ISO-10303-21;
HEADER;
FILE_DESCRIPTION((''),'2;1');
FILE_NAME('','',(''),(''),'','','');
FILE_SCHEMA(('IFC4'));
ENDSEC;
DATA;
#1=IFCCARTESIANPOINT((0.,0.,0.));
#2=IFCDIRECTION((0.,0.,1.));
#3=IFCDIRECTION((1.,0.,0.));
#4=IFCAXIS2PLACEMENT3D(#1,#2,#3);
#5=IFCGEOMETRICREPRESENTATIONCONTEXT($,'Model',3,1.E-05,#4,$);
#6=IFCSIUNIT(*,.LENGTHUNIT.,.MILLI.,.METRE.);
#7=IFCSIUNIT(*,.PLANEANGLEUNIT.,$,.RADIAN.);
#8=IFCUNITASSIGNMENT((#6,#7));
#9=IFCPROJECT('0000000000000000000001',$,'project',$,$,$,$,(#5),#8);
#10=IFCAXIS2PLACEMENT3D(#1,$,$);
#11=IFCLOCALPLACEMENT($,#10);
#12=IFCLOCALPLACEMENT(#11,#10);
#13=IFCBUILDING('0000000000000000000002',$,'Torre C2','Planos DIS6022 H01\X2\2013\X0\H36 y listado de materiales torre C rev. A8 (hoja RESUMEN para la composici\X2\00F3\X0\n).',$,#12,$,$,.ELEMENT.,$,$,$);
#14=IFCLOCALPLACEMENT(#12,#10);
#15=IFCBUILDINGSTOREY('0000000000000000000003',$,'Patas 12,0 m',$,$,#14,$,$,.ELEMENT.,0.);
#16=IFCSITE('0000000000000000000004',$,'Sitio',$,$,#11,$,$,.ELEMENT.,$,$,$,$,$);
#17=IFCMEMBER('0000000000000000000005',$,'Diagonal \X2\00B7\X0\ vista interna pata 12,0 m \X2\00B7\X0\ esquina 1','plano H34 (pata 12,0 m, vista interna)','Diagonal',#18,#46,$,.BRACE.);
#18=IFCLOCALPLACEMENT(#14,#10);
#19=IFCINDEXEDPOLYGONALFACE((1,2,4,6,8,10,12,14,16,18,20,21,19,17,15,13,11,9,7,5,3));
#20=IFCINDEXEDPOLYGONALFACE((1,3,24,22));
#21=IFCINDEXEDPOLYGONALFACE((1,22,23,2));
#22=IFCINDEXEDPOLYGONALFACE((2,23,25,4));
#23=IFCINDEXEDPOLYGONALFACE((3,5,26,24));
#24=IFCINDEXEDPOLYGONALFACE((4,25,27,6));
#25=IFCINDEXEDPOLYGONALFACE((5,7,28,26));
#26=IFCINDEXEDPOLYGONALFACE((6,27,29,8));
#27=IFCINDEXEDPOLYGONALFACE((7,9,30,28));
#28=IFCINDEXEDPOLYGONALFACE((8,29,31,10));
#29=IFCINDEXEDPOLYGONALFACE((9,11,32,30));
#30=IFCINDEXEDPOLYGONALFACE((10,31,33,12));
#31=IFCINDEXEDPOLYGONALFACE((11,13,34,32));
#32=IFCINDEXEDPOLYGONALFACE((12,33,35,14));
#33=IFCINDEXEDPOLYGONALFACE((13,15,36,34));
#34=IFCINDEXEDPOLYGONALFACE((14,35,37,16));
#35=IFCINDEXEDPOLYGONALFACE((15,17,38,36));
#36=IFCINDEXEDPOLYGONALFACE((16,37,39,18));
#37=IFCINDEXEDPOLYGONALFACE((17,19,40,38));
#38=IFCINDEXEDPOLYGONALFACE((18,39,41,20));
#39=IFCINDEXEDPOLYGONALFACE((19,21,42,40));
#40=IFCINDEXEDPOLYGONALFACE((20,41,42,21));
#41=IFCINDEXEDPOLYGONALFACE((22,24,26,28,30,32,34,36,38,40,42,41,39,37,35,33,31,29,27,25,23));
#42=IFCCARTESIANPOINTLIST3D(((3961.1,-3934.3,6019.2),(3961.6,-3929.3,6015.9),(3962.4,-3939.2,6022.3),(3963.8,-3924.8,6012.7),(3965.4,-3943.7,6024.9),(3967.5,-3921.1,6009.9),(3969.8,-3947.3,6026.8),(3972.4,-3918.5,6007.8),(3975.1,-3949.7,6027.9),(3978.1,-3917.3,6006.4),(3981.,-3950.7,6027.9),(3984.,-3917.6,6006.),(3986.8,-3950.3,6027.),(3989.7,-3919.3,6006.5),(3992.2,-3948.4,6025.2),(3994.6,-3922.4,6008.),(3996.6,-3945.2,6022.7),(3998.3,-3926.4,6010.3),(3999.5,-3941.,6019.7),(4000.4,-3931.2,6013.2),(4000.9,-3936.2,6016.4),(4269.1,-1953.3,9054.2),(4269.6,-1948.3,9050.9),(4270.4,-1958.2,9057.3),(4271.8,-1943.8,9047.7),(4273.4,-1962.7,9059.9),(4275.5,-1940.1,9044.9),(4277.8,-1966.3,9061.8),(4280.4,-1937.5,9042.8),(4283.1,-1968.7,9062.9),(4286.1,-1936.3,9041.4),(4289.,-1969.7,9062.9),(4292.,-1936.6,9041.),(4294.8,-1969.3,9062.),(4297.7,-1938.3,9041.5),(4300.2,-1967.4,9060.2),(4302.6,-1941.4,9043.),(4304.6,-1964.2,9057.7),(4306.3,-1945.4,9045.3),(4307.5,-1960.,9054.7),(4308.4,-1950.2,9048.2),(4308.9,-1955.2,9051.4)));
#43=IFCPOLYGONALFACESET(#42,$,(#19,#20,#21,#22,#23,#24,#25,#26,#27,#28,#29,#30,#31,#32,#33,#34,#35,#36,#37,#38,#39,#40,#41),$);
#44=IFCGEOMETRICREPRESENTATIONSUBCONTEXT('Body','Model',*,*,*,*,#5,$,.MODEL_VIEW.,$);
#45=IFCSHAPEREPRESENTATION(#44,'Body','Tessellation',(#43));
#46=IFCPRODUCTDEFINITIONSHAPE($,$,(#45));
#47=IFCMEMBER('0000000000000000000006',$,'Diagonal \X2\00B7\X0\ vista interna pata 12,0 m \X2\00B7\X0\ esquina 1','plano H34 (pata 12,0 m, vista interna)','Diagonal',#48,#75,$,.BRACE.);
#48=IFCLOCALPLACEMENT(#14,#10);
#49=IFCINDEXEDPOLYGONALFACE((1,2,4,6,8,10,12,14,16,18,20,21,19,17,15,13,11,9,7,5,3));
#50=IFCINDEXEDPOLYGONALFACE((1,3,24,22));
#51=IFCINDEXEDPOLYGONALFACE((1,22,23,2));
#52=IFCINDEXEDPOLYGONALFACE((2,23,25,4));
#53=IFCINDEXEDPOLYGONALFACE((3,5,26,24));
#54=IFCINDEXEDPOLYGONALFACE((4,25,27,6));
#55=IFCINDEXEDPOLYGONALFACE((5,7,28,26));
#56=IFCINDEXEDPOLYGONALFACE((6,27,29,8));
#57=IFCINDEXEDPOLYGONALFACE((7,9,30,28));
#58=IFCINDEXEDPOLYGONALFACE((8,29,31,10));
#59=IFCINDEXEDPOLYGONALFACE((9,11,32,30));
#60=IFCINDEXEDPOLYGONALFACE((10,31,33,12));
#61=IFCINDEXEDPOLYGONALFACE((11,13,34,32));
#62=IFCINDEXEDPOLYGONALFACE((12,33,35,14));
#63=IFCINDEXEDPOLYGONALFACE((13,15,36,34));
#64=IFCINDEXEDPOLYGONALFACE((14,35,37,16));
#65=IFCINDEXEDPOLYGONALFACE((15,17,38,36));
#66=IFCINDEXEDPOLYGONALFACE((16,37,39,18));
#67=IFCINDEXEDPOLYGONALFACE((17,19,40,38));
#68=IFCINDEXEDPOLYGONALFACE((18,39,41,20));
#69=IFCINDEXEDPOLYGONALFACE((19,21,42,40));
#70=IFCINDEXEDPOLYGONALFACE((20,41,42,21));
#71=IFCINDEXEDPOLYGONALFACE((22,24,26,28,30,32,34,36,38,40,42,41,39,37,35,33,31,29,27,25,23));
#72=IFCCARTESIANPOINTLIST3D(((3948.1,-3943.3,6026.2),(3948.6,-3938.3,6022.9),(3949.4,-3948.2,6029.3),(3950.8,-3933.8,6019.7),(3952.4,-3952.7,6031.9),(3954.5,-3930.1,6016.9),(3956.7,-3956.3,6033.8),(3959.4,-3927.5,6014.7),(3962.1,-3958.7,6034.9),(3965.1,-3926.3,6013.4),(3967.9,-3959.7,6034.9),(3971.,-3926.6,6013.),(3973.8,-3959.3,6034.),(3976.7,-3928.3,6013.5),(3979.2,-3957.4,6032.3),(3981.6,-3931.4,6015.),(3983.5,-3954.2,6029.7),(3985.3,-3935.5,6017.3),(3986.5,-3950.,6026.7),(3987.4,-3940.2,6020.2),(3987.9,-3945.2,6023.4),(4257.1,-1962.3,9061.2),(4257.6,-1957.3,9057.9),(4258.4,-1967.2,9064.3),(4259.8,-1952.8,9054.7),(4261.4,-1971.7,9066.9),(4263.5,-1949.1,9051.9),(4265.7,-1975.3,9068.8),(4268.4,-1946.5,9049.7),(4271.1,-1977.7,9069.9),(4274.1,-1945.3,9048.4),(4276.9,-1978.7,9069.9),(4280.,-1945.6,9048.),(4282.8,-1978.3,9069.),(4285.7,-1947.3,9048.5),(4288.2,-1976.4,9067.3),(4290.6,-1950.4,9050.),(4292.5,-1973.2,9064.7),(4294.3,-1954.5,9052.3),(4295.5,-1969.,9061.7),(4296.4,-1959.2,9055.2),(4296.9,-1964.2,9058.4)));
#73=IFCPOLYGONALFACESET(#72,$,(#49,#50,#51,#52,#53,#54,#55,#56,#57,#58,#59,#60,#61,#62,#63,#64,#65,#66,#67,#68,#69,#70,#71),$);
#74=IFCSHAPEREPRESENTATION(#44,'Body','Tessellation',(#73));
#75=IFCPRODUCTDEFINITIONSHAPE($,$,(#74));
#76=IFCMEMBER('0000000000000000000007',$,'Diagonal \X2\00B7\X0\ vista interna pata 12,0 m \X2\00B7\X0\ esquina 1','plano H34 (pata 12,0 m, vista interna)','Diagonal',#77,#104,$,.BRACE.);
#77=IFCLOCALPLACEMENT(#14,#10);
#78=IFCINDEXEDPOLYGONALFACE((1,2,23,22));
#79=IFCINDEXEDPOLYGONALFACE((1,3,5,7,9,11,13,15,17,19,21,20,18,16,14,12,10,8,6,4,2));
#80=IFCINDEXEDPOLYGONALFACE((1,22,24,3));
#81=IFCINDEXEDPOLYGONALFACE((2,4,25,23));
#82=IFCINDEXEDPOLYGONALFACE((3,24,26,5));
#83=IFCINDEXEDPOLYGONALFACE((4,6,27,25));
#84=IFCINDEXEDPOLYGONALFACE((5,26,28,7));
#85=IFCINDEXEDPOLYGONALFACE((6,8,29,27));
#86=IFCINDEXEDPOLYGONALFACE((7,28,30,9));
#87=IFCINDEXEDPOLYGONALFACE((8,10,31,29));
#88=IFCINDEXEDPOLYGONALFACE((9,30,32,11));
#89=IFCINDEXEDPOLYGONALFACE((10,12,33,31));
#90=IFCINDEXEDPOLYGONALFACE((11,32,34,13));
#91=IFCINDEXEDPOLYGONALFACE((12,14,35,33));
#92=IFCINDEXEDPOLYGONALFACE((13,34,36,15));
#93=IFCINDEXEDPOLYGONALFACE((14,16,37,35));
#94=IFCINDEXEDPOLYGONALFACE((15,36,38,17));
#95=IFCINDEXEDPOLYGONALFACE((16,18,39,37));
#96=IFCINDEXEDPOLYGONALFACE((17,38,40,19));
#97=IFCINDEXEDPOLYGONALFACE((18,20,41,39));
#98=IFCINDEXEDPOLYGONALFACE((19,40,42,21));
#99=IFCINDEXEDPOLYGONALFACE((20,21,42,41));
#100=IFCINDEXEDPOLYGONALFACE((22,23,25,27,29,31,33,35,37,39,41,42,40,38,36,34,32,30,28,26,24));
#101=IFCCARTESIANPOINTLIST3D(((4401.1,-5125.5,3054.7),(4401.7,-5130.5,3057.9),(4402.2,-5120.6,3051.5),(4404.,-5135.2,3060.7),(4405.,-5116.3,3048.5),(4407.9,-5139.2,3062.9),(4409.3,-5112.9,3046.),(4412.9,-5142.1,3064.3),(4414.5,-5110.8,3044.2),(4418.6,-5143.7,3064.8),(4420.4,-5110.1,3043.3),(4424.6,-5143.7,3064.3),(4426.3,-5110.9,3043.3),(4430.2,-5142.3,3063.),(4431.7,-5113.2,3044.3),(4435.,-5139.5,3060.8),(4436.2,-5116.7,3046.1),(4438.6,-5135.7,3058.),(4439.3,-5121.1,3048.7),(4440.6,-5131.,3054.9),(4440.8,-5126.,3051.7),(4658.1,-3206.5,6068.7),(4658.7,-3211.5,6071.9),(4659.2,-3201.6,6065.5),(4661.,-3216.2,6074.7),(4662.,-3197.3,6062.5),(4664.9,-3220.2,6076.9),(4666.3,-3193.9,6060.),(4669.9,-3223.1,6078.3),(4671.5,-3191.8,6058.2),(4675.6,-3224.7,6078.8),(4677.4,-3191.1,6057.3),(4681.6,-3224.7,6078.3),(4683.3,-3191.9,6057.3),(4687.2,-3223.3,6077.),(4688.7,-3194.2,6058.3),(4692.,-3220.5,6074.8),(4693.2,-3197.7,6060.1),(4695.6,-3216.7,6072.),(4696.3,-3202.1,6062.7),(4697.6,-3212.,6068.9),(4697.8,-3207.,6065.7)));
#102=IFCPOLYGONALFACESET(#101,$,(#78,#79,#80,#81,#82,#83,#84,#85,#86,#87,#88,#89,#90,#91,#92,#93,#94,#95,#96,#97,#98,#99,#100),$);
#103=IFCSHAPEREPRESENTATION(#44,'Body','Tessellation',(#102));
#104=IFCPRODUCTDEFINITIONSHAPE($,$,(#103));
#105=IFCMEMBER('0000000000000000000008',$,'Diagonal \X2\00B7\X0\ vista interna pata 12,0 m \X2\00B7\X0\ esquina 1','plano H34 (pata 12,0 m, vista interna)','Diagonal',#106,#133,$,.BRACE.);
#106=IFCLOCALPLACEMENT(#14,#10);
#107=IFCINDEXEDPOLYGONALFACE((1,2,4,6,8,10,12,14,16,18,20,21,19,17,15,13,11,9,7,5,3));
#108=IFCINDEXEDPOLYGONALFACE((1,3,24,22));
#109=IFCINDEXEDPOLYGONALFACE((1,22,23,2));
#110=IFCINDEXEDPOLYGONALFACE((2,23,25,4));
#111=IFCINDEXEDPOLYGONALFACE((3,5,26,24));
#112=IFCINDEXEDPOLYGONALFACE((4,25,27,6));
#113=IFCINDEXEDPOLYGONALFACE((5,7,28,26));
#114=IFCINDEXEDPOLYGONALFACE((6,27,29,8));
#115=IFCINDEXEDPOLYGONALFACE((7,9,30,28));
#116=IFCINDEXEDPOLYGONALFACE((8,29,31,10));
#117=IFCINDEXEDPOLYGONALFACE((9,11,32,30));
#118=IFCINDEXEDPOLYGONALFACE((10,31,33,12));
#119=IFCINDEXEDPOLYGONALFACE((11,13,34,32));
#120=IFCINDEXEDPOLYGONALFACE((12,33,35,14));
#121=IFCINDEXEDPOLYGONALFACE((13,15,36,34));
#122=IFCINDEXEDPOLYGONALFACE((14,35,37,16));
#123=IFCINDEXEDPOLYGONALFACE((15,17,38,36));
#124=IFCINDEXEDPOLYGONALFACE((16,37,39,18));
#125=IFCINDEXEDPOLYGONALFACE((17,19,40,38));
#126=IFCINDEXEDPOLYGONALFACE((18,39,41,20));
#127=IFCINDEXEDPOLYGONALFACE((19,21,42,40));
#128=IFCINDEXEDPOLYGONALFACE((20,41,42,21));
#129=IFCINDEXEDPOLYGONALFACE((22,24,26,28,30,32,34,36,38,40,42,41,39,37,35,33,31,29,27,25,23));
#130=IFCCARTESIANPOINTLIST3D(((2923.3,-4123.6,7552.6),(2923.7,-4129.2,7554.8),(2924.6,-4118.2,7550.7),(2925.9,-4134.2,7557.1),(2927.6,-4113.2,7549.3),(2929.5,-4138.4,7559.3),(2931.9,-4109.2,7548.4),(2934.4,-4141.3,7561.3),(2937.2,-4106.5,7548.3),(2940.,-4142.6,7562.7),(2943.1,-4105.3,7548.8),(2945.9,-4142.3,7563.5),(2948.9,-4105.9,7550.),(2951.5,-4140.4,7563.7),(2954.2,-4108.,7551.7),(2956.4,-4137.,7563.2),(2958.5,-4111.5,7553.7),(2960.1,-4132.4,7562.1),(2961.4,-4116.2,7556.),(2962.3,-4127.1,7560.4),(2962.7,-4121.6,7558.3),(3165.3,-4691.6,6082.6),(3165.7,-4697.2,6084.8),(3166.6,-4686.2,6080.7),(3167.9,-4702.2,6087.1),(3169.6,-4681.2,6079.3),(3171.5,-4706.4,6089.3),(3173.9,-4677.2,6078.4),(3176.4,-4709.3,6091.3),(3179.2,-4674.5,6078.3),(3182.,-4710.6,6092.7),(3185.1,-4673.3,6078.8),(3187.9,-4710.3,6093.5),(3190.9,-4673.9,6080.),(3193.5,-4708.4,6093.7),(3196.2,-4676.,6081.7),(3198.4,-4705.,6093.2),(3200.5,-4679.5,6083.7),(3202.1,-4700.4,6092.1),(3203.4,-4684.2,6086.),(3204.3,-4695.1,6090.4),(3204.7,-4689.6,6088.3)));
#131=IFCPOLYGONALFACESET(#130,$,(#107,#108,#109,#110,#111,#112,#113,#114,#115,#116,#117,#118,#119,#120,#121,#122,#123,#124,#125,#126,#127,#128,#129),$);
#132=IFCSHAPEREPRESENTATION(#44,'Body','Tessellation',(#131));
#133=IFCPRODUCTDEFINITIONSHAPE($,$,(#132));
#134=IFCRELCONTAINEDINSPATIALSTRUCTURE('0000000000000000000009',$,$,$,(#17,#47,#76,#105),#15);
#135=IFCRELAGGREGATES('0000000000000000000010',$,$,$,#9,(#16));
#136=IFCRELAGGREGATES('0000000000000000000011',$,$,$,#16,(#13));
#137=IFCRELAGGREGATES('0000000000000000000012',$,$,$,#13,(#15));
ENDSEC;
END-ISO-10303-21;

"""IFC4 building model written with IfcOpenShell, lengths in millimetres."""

from ifc_helpers import new_model, si_unit, frame, origin, origin_with_axes, place, context, subcontext, project, spatial, circle, extrude, element, save


model = new_model("IFC4")

# Units and contexts
model_context = context("Model", 3, precision=1e-05, world=origin_with_axes())
body_context = subcontext(model_context, "Body", "Model", "MODEL_VIEW")
ifc_project = project(units=[si_unit("LENGTHUNIT", "METRE", prefix="MILLI"), si_unit("PLANEANGLEUNIT", "RADIAN")], contexts=[model_context])

# Site, building, storey
site_placement = place(None, origin())
site = spatial("IfcSite", under=ifc_project, at=site_placement, Name="Sitio", CompositionType="ELEMENT")
building_placement = place(site_placement, origin())
building = spatial("IfcBuilding", under=site, at=building_placement, Name="Torre C2", Description="Planos DIS6022 H01–H36 y listado de materiales torre C rev. A8 (hoja RESUMEN para la composición).", CompositionType="ELEMENT")
storey_placement = place(building_placement, origin())
storey = spatial("IfcBuildingStorey", under=building, at=storey_placement, Name="Patas 12,0 m", CompositionType="ELEMENT", Elevation=0.0)

# Members
member_1_placement = place(storey_placement, frame((3981.0, -3934.0, 6017.0), z_axis=(0.084677, 0.544624, 0.834394), x_axis=(-0.862259, 0.459706, -0.212554)))
element("IfcMember", 1, at=member_1_placement, inside=storey, Name="Diagonal · vista interna pata 12,0 m · esquina 1", Description="plano H34 (pata 12,0 m, vista interna)", ObjectType="Diagonal", PredefinedType="BRACE", context=body_context, shape_type="SweptSolid", body=[
    extrude(circle(Radius=20.0), None, (0.0, 0.0, 1.0), 3637.4),
])
member_2_placement = place(storey_placement, frame((3968.0, -3943.0, 6024.0), z_axis=(0.08495, 0.544612, 0.834375), x_axis=(-0.860978, 0.461602, -0.213638)))
element("IfcMember", 2, at=member_2_placement, inside=storey, Name="Diagonal · vista interna pata 12,0 m · esquina 1", Description="plano H34 (pata 12,0 m, vista interna)", ObjectType="Diagonal", PredefinedType="BRACE", context=body_context, shape_type="SweptSolid", body=[
    extrude(circle(Radius=20.0), None, (0.0, 0.0, 1.0), 3637.5),
])
member_3_placement = place(storey_placement, frame((4421.0, -5127.0, 3054.0), z_axis=(0.071742, 0.535691, 0.841361), x_axis=(-0.798618, 0.536205, -0.273302)))
element("IfcMember", 3, at=member_3_placement, inside=storey, Name="Diagonal · vista interna pata 12,0 m · esquina 1", Description="plano H34 (pata 12,0 m, vista interna)", ObjectType="Diagonal", PredefinedType="BRACE", context=body_context, shape_type="SweptSolid", body=[
    extrude(circle(Radius=20.0), None, (0.0, 0.0, 1.0), 3582.3),
])
member_4_placement = place(storey_placement, frame((3185.0, -4692.0, 6086.0), z_axis=(-0.151782, 0.356249, 0.921981), x_axis=(-0.554622, 0.741403, -0.377779)))
element("IfcMember", 4, at=member_4_placement, inside=storey, Name="Diagonal · vista interna pata 12,0 m · esquina 1", Description="plano H34 (pata 12,0 m, vista interna)", ObjectType="Diagonal", PredefinedType="BRACE", context=body_context, shape_type="SweptSolid", body=[
    extrude(circle(Radius=20.0), None, (0.0, 0.0, 1.0), 1594.4),
])

save(model, "model.ifc")
